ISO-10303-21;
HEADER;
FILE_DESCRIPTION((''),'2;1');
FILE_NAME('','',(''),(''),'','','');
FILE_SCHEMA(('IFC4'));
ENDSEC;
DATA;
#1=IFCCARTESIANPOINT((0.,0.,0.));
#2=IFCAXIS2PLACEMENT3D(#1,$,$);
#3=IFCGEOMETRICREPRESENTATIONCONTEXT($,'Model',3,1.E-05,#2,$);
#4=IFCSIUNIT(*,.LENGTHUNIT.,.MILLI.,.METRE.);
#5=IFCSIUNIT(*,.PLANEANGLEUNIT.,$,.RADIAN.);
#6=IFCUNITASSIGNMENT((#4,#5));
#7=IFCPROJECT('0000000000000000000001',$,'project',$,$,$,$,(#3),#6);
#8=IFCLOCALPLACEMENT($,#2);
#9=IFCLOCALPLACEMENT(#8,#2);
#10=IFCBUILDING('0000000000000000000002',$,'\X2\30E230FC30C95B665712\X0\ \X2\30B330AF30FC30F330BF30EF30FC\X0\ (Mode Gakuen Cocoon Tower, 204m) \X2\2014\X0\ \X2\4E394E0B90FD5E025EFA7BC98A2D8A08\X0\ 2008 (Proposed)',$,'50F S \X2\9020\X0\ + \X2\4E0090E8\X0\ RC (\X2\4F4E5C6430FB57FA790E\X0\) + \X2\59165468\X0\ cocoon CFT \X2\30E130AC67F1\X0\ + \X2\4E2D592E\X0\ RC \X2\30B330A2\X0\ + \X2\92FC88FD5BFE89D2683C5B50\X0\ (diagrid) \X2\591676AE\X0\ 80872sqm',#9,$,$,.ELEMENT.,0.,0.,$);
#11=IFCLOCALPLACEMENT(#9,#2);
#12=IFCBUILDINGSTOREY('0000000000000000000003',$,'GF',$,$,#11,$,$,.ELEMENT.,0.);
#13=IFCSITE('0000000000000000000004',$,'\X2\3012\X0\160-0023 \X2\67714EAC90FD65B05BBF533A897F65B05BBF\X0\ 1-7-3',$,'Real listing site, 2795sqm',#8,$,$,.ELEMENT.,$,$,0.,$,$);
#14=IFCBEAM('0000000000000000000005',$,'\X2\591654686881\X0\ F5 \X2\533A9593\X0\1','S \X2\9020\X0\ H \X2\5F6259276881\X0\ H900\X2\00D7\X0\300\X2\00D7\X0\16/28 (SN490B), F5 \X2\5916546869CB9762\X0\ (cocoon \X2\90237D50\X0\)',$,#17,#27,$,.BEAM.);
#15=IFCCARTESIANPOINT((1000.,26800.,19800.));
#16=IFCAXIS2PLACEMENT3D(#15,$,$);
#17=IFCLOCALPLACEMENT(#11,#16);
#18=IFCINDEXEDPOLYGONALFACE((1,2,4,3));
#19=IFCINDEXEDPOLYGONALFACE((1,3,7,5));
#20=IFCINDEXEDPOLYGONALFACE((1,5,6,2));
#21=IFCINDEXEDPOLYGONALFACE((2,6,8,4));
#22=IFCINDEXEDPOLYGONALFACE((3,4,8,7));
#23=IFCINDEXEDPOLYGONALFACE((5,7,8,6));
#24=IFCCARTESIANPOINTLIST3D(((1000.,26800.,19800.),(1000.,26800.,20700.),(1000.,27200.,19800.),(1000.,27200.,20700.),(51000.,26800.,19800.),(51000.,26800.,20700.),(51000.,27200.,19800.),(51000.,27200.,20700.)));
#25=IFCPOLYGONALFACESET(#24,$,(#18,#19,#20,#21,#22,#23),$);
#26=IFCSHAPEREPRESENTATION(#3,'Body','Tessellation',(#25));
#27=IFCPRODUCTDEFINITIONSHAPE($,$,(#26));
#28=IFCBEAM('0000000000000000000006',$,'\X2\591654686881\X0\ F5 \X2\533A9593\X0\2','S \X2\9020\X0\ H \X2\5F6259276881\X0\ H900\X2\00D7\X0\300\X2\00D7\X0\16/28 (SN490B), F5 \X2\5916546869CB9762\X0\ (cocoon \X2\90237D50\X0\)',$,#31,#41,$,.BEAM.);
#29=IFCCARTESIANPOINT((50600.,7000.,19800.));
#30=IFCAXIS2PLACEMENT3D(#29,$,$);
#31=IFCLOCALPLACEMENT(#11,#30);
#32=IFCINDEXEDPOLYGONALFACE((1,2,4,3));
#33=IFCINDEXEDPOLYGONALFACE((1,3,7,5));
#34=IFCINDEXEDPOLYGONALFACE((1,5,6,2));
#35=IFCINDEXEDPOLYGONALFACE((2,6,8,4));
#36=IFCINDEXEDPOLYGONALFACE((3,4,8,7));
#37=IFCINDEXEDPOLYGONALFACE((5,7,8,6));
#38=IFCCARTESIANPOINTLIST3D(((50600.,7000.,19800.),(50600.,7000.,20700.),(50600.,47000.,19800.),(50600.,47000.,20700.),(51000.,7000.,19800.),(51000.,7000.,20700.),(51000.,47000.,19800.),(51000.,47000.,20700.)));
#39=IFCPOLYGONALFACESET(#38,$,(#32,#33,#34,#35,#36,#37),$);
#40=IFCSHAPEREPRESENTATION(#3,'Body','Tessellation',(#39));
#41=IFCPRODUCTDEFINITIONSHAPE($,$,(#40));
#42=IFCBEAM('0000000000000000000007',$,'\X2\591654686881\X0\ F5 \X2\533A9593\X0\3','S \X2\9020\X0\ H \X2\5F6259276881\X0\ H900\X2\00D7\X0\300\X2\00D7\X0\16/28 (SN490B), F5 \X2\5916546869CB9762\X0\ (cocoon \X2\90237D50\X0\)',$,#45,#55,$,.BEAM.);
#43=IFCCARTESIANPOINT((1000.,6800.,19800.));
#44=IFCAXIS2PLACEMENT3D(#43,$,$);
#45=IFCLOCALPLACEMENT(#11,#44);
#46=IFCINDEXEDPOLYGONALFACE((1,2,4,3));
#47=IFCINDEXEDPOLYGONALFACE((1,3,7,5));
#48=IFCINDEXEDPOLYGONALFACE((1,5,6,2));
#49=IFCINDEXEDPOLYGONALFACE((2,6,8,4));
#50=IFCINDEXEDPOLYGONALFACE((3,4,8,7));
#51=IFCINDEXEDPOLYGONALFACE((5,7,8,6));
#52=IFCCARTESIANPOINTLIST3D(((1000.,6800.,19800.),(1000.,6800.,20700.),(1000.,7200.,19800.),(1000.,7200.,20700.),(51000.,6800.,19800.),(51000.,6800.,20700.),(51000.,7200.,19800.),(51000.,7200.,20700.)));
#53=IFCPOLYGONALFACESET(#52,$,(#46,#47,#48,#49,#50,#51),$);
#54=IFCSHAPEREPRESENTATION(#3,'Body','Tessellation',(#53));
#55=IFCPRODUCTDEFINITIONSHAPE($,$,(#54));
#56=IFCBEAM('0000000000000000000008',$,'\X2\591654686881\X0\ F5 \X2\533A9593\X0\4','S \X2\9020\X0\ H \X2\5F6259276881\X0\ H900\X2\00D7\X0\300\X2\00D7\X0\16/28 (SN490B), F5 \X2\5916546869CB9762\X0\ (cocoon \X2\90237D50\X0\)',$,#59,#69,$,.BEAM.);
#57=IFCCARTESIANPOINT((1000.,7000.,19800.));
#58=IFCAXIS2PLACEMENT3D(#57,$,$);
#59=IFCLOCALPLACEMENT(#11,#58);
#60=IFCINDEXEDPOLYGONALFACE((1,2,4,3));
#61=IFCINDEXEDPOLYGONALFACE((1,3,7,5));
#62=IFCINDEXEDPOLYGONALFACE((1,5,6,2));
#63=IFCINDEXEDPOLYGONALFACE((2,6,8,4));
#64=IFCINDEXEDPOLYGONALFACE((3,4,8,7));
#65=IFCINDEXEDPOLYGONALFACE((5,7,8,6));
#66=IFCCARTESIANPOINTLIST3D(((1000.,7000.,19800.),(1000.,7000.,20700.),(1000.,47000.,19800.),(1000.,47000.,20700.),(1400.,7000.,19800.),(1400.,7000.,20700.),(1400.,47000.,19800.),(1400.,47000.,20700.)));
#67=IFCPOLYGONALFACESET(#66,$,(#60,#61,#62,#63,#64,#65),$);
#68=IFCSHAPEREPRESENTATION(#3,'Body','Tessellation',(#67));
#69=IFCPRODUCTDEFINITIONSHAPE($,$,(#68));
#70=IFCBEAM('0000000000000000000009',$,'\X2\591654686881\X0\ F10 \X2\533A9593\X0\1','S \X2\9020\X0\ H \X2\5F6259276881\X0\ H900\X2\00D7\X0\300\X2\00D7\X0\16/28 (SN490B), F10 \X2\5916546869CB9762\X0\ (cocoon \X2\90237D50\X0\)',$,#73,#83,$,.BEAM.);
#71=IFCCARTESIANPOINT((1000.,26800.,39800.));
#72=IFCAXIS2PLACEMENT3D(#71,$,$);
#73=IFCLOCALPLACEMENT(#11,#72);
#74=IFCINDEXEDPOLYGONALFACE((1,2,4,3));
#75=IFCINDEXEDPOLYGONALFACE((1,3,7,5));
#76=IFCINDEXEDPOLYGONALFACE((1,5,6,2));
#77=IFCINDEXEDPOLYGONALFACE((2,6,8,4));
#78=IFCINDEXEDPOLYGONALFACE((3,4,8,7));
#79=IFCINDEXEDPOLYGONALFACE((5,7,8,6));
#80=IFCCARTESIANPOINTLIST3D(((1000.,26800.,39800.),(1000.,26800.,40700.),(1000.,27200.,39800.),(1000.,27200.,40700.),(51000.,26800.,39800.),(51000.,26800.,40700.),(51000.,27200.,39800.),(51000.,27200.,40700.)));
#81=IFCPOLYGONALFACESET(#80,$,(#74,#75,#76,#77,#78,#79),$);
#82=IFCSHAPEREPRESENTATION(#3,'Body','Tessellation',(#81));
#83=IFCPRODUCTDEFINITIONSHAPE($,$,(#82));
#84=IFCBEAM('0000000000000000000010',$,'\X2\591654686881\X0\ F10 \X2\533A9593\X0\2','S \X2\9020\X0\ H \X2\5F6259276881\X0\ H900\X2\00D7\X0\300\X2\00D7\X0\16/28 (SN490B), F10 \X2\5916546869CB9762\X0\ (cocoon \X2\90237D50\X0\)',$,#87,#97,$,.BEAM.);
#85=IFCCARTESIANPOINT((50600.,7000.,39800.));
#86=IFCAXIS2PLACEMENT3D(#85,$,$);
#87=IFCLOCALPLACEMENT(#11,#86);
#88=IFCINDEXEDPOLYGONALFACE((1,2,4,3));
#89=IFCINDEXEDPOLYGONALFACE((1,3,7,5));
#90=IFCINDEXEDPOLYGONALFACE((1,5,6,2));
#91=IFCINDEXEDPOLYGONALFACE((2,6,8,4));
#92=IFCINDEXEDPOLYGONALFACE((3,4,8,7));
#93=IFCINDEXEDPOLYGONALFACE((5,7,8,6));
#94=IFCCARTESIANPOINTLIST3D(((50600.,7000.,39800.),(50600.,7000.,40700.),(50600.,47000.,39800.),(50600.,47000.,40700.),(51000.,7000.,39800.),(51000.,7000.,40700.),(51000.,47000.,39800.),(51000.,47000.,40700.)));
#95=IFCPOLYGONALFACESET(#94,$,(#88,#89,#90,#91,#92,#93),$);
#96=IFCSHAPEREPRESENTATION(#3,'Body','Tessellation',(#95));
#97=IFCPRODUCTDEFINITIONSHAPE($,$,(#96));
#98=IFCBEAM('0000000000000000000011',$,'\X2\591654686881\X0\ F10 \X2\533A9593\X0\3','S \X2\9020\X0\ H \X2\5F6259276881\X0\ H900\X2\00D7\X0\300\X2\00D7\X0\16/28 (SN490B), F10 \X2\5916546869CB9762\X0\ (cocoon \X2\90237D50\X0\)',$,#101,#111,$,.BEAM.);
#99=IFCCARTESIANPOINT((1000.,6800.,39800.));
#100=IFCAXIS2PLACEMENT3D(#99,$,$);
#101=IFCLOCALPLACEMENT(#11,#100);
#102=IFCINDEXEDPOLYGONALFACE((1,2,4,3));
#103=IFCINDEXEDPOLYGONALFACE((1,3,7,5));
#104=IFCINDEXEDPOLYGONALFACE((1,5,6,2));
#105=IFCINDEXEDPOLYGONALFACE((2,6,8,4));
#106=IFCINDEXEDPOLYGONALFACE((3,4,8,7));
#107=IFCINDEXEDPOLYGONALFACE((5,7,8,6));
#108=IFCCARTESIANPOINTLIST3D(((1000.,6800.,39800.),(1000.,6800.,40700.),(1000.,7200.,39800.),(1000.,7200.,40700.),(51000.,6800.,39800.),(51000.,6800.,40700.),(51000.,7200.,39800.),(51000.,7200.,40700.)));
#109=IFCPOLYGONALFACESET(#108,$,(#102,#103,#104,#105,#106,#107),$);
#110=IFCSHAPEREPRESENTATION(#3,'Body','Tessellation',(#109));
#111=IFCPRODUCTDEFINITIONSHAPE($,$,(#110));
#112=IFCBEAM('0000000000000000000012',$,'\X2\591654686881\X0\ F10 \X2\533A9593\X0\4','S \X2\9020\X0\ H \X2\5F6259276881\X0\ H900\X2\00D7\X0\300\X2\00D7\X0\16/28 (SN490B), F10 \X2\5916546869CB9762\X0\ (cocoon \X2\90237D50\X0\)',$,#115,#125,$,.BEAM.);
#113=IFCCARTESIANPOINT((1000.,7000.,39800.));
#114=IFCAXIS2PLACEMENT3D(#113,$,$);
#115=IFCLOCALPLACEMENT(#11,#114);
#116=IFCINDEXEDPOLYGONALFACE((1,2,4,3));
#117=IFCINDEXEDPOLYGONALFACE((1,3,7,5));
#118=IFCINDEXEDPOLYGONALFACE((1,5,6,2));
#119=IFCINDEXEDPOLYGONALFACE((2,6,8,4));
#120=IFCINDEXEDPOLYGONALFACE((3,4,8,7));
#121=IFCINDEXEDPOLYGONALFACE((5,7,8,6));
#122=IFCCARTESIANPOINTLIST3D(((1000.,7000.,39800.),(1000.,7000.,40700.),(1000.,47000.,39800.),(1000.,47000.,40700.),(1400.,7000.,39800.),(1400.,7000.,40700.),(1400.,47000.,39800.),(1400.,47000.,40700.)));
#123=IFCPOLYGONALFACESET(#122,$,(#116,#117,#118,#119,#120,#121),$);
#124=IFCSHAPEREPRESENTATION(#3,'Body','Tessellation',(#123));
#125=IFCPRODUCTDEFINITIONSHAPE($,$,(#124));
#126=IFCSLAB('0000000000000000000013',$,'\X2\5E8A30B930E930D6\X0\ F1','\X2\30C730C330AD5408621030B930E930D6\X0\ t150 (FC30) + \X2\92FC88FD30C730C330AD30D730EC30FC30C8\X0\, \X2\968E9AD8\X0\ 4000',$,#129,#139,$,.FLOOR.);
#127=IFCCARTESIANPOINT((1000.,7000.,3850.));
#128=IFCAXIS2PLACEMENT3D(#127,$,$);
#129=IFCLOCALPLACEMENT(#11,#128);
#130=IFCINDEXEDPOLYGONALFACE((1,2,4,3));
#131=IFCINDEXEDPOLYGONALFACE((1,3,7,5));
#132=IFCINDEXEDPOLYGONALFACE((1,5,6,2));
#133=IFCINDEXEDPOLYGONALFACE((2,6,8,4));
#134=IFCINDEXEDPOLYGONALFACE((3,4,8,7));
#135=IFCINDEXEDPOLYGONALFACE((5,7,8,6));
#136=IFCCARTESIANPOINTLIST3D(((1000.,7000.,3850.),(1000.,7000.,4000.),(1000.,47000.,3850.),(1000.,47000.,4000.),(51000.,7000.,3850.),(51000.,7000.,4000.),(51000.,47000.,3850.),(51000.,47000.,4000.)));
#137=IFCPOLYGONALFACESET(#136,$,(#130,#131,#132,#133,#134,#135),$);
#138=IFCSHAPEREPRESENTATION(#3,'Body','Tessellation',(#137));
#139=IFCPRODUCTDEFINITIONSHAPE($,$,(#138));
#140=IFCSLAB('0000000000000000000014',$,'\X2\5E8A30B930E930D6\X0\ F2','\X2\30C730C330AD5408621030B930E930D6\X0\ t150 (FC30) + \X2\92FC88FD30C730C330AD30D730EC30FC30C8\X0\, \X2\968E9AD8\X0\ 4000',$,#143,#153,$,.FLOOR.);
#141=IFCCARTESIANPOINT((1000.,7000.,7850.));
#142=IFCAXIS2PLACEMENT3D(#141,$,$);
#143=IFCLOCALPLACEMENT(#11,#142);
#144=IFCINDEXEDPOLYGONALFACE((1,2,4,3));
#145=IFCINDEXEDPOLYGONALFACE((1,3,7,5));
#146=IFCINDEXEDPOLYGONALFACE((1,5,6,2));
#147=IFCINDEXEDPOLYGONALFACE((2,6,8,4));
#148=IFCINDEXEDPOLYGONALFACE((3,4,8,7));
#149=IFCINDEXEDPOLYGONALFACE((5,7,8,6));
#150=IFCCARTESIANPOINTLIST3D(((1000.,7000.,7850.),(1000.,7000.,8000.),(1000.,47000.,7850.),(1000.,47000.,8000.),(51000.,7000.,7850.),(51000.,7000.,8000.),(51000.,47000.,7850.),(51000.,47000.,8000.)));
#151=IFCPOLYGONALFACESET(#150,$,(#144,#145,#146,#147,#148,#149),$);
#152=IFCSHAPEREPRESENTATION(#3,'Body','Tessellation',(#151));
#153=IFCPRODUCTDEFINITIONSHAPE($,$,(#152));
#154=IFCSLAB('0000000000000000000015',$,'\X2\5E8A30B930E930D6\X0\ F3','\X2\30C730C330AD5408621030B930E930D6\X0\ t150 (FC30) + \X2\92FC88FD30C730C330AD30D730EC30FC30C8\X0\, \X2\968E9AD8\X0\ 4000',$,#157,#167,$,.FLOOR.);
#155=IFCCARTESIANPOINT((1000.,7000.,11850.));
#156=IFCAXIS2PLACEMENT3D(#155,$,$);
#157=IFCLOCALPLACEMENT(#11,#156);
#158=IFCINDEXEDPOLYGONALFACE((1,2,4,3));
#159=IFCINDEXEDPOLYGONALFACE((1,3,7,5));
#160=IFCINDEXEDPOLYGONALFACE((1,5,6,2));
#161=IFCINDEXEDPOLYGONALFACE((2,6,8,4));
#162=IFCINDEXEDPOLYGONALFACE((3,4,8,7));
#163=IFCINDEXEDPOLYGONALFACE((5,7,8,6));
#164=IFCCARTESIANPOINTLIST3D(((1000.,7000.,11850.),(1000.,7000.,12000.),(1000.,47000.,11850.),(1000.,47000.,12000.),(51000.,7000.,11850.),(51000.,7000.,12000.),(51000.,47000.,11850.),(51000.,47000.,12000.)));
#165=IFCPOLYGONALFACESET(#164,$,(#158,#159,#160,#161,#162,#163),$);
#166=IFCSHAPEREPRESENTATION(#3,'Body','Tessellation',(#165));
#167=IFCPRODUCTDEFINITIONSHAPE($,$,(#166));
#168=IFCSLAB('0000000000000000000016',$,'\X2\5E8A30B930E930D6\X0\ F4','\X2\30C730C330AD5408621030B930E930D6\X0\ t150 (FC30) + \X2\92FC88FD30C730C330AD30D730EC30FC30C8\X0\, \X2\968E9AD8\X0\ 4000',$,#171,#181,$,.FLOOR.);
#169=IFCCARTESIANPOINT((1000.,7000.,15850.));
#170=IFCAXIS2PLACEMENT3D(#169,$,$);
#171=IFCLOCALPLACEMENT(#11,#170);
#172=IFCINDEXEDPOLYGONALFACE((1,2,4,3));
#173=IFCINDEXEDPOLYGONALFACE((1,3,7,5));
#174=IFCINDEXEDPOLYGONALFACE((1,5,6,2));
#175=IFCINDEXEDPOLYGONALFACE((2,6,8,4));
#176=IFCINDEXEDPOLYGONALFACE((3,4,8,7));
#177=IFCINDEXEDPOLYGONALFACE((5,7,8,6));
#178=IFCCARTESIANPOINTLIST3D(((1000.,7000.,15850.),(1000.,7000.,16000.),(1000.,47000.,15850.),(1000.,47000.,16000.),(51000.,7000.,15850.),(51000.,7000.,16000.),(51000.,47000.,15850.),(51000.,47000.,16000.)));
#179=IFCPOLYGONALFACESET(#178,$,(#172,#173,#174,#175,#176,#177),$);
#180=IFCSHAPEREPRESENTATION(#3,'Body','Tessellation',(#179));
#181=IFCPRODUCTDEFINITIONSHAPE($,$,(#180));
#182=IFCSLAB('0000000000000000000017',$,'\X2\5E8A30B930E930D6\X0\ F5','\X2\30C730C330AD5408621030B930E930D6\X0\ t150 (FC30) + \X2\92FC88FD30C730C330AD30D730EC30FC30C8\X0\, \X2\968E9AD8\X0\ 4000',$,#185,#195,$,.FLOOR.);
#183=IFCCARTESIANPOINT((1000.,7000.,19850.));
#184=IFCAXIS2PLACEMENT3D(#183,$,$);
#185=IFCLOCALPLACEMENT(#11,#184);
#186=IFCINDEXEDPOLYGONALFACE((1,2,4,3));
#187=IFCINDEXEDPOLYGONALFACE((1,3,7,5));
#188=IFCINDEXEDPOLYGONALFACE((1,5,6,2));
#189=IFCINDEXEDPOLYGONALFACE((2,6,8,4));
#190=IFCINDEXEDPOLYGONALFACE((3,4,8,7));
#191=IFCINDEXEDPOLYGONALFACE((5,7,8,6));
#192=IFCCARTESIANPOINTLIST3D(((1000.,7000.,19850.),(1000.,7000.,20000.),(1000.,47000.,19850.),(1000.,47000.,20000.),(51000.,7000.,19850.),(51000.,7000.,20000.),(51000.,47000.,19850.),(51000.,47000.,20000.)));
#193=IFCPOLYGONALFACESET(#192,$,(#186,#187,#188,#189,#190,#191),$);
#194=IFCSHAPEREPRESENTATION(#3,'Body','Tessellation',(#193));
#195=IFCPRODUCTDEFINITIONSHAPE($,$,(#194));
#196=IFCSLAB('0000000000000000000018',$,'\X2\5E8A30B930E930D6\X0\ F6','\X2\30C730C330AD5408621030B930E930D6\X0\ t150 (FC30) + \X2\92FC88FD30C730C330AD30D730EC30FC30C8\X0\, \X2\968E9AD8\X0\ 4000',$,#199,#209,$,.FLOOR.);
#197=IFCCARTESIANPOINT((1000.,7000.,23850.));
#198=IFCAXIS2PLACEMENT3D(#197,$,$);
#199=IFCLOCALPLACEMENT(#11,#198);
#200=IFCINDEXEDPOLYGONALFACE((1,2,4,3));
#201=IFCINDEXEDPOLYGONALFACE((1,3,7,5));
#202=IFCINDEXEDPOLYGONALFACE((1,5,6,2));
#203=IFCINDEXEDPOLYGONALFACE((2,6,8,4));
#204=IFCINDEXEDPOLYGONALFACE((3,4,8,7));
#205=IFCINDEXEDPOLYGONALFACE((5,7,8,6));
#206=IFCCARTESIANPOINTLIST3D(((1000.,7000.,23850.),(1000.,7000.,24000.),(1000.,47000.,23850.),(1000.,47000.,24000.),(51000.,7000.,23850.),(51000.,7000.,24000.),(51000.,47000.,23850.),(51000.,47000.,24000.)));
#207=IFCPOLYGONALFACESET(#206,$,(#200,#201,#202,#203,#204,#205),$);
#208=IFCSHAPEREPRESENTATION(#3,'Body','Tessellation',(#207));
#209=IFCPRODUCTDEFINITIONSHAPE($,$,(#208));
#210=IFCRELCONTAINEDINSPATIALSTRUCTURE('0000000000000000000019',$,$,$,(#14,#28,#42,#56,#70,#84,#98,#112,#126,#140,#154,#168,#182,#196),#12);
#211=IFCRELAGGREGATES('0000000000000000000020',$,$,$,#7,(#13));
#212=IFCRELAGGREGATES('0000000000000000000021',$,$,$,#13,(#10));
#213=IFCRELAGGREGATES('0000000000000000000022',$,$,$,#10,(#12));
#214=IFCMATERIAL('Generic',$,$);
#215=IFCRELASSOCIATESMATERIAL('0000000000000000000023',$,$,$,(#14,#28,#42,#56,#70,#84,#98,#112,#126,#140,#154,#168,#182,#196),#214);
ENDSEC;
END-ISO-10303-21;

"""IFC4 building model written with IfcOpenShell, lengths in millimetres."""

from ifc_helpers import new_model, si_unit, frame, frame_2d, origin, place, context, project, spatial, rectangle, extrude, material, element, save


model = new_model("IFC4")

# Units and contexts
model_context = context("Model", 3, precision=1e-05, world=origin())
ifc_project = project(units=[si_unit("LENGTHUNIT", "METRE", prefix="MILLI"), si_unit("PLANEANGLEUNIT", "RADIAN")], contexts=[model_context])

# Site, building, storey
site_placement = place(None, origin())
site = spatial("IfcSite", under=ifc_project, at=site_placement, Name="〒160-0023 東京都新宿区西新宿 1-7-3", ObjectType="Real listing site, 2795sqm", CompositionType="ELEMENT", RefElevation=0.0)
building_placement = place(site_placement, origin())
building = spatial("IfcBuilding", under=site, at=building_placement, Name="モード学園 コクーンタワー (Mode Gakuen Cocoon Tower, 204m) — 丹下都市建築設計 2008 (Proposed)", ObjectType="50F S 造 + 一部 RC (低層・基礎) + 外周 cocoon CFT メガ柱 + 中央 RC コア + 鋼製対角格子 (diagrid) 外皮 80872sqm", CompositionType="ELEMENT", ElevationOfRefHeight=0.0, ElevationOfTerrain=0.0)
storey_placement = place(building_placement, origin())
storey = spatial("IfcBuildingStorey", under=building, at=storey_placement, Name="GF", CompositionType="ELEMENT", Elevation=0.0)

# Beams
ifc_material_1 = material(Name="Generic")
beam_1_placement = place(storey_placement, frame((1000.0, 26800.0, 19800.0)))
element("IfcBeam", 1, at=beam_1_placement, inside=storey, material=ifc_material_1, Name="外周梁 F5 区間1", Description="S 造 H 形大梁 H900×300×16/28 (SN490B), F5 外周構面 (cocoon 連結)", PredefinedType="BEAM", context=model_context, shape_type="SweptSolid", body=[
    extrude(rectangle(XDim=50000.0, YDim=400.0, at=frame_2d((25000.0, 200.0))), frame((1000.0, 26800.0, 19800.0)), (0.0, 0.0, 1.0), 900.0),
])
beam_2_placement = place(storey_placement, frame((50600.0, 7000.0, 19800.0)))
element("IfcBeam", 2, at=beam_2_placement, inside=storey, material=ifc_material_1, Name="外周梁 F5 区間2", Description="S 造 H 形大梁 H900×300×16/28 (SN490B), F5 外周構面 (cocoon 連結)", PredefinedType="BEAM", context=model_context, shape_type="SweptSolid", body=[
    extrude(rectangle(XDim=400.0, YDim=40000.0, at=frame_2d((200.0, 20000.0))), frame((50600.0, 7000.0, 19800.0)), (0.0, 0.0, 1.0), 900.0),
])
beam_3_placement = place(storey_placement, frame((1000.0, 6800.0, 19800.0)))
element("IfcBeam", 3, at=beam_3_placement, inside=storey, material=ifc_material_1, Name="外周梁 F5 区間3", Description="S 造 H 形大梁 H900×300×16/28 (SN490B), F5 外周構面 (cocoon 連結)", PredefinedType="BEAM", context=model_context, shape_type="SweptSolid", body=[
    extrude(rectangle(XDim=50000.0, YDim=400.0, at=frame_2d((25000.0, 200.0))), frame((1000.0, 6800.0, 19800.0)), (0.0, 0.0, 1.0), 900.0),
])
beam_4_placement = place(storey_placement, frame((1000.0, 7000.0, 19800.0)))
element("IfcBeam", 4, at=beam_4_placement, inside=storey, material=ifc_material_1, Name="外周梁 F5 区間4", Description="S 造 H 形大梁 H900×300×16/28 (SN490B), F5 外周構面 (cocoon 連結)", PredefinedType="BEAM", context=model_context, shape_type="SweptSolid", body=[
    extrude(rectangle(XDim=400.0, YDim=40000.0, at=frame_2d((200.0, 20000.0))), frame((1000.0, 7000.0, 19800.0)), (0.0, 0.0, 1.0), 900.0),
])
beam_5_placement = place(storey_placement, frame((1000.0, 26800.0, 39800.0)))
element("IfcBeam", 5, at=beam_5_placement, inside=storey, material=ifc_material_1, Name="外周梁 F10 区間1", Description="S 造 H 形大梁 H900×300×16/28 (SN490B), F10 外周構面 (cocoon 連結)", PredefinedType="BEAM", context=model_context, shape_type="SweptSolid", body=[
    extrude(rectangle(XDim=50000.0, YDim=400.0, at=frame_2d((25000.0, 200.0))), frame((1000.0, 26800.0, 39800.0)), (0.0, 0.0, 1.0), 900.0),
])
beam_6_placement = place(storey_placement, frame((50600.0, 7000.0, 39800.0)))
element("IfcBeam", 6, at=beam_6_placement, inside=storey, material=ifc_material_1, Name="外周梁 F10 区間2", Description="S 造 H 形大梁 H900×300×16/28 (SN490B), F10 外周構面 (cocoon 連結)", PredefinedType="BEAM", context=model_context, shape_type="SweptSolid", body=[
    extrude(rectangle(XDim=400.0, YDim=40000.0, at=frame_2d((200.0, 20000.0))), frame((50600.0, 7000.0, 39800.0)), (0.0, 0.0, 1.0), 900.0),
])
beam_7_placement = place(storey_placement, frame((1000.0, 6800.0, 39800.0)))
element("IfcBeam", 7, at=beam_7_placement, inside=storey, material=ifc_material_1, Name="外周梁 F10 区間3", Description="S 造 H 形大梁 H900×300×16/28 (SN490B), F10 外周構面 (cocoon 連結)", PredefinedType="BEAM", context=model_context, shape_type="SweptSolid", body=[
    extrude(rectangle(XDim=50000.0, YDim=400.0, at=frame_2d((25000.0, 200.0))), frame((1000.0, 6800.0, 39800.0)), (0.0, 0.0, 1.0), 900.0),
])
beam_8_placement = place(storey_placement, frame((1000.0, 7000.0, 39800.0)))
element("IfcBeam", 8, at=beam_8_placement, inside=storey, material=ifc_material_1, Name="外周梁 F10 区間4", Description="S 造 H 形大梁 H900×300×16/28 (SN490B), F10 外周構面 (cocoon 連結)", PredefinedType="BEAM", context=model_context, shape_type="SweptSolid", body=[
    extrude(rectangle(XDim=400.0, YDim=40000.0, at=frame_2d((200.0, 20000.0))), frame((1000.0, 7000.0, 39800.0)), (0.0, 0.0, 1.0), 900.0),
])

# Slabs
slab_1_placement = place(storey_placement, frame((1000.0, 7000.0, 3850.0)))
element("IfcSlab", 9, at=slab_1_placement, inside=storey, material=ifc_material_1, Name="床スラブ F1", Description="デッキ合成スラブ t150 (FC30) + 鋼製デッキプレート, 階高 4000", PredefinedType="FLOOR", context=model_context, shape_type="SweptSolid", body=[
    extrude(rectangle(XDim=50000.0, YDim=40000.0, at=frame_2d((25000.0, 20000.0))), frame((1000.0, 7000.0, 3850.0)), (0.0, 0.0, 1.0), 150.0),
])
slab_2_placement = place(storey_placement, frame((1000.0, 7000.0, 7850.0)))
element("IfcSlab", 10, at=slab_2_placement, inside=storey, material=ifc_material_1, Name="床スラブ F2", Description="デッキ合成スラブ t150 (FC30) + 鋼製デッキプレート, 階高 4000", PredefinedType="FLOOR", context=model_context, shape_type="SweptSolid", body=[
    extrude(rectangle(XDim=50000.0, YDim=40000.0, at=frame_2d((25000.0, 20000.0))), frame((1000.0, 7000.0, 7850.0)), (0.0, 0.0, 1.0), 150.0),
])
slab_3_placement = place(storey_placement, frame((1000.0, 7000.0, 11850.0)))
element("IfcSlab", 11, at=slab_3_placement, inside=storey, material=ifc_material_1, Name="床スラブ F3", Description="デッキ合成スラブ t150 (FC30) + 鋼製デッキプレート, 階高 4000", PredefinedType="FLOOR", context=model_context, shape_type="SweptSolid", body=[
    extrude(rectangle(XDim=50000.0, YDim=40000.0, at=frame_2d((25000.0, 20000.0))), frame((1000.0, 7000.0, 11850.0)), (0.0, 0.0, 1.0), 150.0),
])
slab_4_placement = place(storey_placement, frame((1000.0, 7000.0, 15850.0)))
element("IfcSlab", 12, at=slab_4_placement, inside=storey, material=ifc_material_1, Name="床スラブ F4", Description="デッキ合成スラブ t150 (FC30) + 鋼製デッキプレート, 階高 4000", PredefinedType="FLOOR", context=model_context, shape_type="SweptSolid", body=[
    extrude(rectangle(XDim=50000.0, YDim=40000.0, at=frame_2d((25000.0, 20000.0))), frame((1000.0, 7000.0, 15850.0)), (0.0, 0.0, 1.0), 150.0),
])
slab_5_placement = place(storey_placement, frame((1000.0, 7000.0, 19850.0)))
element("IfcSlab", 13, at=slab_5_placement, inside=storey, material=ifc_material_1, Name="床スラブ F5", Description="デッキ合成スラブ t150 (FC30) + 鋼製デッキプレート, 階高 4000", PredefinedType="FLOOR", context=model_context, shape_type="SweptSolid", body=[
    extrude(rectangle(XDim=50000.0, YDim=40000.0, at=frame_2d((25000.0, 20000.0))), frame((1000.0, 7000.0, 19850.0)), (0.0, 0.0, 1.0), 150.0),
])
slab_6_placement = place(storey_placement, frame((1000.0, 7000.0, 23850.0)))
element("IfcSlab", 14, at=slab_6_placement, inside=storey, material=ifc_material_1, Name="床スラブ F6", Description="デッキ合成スラブ t150 (FC30) + 鋼製デッキプレート, 階高 4000", PredefinedType="FLOOR", context=model_context, shape_type="SweptSolid", body=[
    extrude(rectangle(XDim=50000.0, YDim=40000.0, at=frame_2d((25000.0, 20000.0))), frame((1000.0, 7000.0, 23850.0)), (0.0, 0.0, 1.0), 150.0),
])

save(model, "model.ifc")
